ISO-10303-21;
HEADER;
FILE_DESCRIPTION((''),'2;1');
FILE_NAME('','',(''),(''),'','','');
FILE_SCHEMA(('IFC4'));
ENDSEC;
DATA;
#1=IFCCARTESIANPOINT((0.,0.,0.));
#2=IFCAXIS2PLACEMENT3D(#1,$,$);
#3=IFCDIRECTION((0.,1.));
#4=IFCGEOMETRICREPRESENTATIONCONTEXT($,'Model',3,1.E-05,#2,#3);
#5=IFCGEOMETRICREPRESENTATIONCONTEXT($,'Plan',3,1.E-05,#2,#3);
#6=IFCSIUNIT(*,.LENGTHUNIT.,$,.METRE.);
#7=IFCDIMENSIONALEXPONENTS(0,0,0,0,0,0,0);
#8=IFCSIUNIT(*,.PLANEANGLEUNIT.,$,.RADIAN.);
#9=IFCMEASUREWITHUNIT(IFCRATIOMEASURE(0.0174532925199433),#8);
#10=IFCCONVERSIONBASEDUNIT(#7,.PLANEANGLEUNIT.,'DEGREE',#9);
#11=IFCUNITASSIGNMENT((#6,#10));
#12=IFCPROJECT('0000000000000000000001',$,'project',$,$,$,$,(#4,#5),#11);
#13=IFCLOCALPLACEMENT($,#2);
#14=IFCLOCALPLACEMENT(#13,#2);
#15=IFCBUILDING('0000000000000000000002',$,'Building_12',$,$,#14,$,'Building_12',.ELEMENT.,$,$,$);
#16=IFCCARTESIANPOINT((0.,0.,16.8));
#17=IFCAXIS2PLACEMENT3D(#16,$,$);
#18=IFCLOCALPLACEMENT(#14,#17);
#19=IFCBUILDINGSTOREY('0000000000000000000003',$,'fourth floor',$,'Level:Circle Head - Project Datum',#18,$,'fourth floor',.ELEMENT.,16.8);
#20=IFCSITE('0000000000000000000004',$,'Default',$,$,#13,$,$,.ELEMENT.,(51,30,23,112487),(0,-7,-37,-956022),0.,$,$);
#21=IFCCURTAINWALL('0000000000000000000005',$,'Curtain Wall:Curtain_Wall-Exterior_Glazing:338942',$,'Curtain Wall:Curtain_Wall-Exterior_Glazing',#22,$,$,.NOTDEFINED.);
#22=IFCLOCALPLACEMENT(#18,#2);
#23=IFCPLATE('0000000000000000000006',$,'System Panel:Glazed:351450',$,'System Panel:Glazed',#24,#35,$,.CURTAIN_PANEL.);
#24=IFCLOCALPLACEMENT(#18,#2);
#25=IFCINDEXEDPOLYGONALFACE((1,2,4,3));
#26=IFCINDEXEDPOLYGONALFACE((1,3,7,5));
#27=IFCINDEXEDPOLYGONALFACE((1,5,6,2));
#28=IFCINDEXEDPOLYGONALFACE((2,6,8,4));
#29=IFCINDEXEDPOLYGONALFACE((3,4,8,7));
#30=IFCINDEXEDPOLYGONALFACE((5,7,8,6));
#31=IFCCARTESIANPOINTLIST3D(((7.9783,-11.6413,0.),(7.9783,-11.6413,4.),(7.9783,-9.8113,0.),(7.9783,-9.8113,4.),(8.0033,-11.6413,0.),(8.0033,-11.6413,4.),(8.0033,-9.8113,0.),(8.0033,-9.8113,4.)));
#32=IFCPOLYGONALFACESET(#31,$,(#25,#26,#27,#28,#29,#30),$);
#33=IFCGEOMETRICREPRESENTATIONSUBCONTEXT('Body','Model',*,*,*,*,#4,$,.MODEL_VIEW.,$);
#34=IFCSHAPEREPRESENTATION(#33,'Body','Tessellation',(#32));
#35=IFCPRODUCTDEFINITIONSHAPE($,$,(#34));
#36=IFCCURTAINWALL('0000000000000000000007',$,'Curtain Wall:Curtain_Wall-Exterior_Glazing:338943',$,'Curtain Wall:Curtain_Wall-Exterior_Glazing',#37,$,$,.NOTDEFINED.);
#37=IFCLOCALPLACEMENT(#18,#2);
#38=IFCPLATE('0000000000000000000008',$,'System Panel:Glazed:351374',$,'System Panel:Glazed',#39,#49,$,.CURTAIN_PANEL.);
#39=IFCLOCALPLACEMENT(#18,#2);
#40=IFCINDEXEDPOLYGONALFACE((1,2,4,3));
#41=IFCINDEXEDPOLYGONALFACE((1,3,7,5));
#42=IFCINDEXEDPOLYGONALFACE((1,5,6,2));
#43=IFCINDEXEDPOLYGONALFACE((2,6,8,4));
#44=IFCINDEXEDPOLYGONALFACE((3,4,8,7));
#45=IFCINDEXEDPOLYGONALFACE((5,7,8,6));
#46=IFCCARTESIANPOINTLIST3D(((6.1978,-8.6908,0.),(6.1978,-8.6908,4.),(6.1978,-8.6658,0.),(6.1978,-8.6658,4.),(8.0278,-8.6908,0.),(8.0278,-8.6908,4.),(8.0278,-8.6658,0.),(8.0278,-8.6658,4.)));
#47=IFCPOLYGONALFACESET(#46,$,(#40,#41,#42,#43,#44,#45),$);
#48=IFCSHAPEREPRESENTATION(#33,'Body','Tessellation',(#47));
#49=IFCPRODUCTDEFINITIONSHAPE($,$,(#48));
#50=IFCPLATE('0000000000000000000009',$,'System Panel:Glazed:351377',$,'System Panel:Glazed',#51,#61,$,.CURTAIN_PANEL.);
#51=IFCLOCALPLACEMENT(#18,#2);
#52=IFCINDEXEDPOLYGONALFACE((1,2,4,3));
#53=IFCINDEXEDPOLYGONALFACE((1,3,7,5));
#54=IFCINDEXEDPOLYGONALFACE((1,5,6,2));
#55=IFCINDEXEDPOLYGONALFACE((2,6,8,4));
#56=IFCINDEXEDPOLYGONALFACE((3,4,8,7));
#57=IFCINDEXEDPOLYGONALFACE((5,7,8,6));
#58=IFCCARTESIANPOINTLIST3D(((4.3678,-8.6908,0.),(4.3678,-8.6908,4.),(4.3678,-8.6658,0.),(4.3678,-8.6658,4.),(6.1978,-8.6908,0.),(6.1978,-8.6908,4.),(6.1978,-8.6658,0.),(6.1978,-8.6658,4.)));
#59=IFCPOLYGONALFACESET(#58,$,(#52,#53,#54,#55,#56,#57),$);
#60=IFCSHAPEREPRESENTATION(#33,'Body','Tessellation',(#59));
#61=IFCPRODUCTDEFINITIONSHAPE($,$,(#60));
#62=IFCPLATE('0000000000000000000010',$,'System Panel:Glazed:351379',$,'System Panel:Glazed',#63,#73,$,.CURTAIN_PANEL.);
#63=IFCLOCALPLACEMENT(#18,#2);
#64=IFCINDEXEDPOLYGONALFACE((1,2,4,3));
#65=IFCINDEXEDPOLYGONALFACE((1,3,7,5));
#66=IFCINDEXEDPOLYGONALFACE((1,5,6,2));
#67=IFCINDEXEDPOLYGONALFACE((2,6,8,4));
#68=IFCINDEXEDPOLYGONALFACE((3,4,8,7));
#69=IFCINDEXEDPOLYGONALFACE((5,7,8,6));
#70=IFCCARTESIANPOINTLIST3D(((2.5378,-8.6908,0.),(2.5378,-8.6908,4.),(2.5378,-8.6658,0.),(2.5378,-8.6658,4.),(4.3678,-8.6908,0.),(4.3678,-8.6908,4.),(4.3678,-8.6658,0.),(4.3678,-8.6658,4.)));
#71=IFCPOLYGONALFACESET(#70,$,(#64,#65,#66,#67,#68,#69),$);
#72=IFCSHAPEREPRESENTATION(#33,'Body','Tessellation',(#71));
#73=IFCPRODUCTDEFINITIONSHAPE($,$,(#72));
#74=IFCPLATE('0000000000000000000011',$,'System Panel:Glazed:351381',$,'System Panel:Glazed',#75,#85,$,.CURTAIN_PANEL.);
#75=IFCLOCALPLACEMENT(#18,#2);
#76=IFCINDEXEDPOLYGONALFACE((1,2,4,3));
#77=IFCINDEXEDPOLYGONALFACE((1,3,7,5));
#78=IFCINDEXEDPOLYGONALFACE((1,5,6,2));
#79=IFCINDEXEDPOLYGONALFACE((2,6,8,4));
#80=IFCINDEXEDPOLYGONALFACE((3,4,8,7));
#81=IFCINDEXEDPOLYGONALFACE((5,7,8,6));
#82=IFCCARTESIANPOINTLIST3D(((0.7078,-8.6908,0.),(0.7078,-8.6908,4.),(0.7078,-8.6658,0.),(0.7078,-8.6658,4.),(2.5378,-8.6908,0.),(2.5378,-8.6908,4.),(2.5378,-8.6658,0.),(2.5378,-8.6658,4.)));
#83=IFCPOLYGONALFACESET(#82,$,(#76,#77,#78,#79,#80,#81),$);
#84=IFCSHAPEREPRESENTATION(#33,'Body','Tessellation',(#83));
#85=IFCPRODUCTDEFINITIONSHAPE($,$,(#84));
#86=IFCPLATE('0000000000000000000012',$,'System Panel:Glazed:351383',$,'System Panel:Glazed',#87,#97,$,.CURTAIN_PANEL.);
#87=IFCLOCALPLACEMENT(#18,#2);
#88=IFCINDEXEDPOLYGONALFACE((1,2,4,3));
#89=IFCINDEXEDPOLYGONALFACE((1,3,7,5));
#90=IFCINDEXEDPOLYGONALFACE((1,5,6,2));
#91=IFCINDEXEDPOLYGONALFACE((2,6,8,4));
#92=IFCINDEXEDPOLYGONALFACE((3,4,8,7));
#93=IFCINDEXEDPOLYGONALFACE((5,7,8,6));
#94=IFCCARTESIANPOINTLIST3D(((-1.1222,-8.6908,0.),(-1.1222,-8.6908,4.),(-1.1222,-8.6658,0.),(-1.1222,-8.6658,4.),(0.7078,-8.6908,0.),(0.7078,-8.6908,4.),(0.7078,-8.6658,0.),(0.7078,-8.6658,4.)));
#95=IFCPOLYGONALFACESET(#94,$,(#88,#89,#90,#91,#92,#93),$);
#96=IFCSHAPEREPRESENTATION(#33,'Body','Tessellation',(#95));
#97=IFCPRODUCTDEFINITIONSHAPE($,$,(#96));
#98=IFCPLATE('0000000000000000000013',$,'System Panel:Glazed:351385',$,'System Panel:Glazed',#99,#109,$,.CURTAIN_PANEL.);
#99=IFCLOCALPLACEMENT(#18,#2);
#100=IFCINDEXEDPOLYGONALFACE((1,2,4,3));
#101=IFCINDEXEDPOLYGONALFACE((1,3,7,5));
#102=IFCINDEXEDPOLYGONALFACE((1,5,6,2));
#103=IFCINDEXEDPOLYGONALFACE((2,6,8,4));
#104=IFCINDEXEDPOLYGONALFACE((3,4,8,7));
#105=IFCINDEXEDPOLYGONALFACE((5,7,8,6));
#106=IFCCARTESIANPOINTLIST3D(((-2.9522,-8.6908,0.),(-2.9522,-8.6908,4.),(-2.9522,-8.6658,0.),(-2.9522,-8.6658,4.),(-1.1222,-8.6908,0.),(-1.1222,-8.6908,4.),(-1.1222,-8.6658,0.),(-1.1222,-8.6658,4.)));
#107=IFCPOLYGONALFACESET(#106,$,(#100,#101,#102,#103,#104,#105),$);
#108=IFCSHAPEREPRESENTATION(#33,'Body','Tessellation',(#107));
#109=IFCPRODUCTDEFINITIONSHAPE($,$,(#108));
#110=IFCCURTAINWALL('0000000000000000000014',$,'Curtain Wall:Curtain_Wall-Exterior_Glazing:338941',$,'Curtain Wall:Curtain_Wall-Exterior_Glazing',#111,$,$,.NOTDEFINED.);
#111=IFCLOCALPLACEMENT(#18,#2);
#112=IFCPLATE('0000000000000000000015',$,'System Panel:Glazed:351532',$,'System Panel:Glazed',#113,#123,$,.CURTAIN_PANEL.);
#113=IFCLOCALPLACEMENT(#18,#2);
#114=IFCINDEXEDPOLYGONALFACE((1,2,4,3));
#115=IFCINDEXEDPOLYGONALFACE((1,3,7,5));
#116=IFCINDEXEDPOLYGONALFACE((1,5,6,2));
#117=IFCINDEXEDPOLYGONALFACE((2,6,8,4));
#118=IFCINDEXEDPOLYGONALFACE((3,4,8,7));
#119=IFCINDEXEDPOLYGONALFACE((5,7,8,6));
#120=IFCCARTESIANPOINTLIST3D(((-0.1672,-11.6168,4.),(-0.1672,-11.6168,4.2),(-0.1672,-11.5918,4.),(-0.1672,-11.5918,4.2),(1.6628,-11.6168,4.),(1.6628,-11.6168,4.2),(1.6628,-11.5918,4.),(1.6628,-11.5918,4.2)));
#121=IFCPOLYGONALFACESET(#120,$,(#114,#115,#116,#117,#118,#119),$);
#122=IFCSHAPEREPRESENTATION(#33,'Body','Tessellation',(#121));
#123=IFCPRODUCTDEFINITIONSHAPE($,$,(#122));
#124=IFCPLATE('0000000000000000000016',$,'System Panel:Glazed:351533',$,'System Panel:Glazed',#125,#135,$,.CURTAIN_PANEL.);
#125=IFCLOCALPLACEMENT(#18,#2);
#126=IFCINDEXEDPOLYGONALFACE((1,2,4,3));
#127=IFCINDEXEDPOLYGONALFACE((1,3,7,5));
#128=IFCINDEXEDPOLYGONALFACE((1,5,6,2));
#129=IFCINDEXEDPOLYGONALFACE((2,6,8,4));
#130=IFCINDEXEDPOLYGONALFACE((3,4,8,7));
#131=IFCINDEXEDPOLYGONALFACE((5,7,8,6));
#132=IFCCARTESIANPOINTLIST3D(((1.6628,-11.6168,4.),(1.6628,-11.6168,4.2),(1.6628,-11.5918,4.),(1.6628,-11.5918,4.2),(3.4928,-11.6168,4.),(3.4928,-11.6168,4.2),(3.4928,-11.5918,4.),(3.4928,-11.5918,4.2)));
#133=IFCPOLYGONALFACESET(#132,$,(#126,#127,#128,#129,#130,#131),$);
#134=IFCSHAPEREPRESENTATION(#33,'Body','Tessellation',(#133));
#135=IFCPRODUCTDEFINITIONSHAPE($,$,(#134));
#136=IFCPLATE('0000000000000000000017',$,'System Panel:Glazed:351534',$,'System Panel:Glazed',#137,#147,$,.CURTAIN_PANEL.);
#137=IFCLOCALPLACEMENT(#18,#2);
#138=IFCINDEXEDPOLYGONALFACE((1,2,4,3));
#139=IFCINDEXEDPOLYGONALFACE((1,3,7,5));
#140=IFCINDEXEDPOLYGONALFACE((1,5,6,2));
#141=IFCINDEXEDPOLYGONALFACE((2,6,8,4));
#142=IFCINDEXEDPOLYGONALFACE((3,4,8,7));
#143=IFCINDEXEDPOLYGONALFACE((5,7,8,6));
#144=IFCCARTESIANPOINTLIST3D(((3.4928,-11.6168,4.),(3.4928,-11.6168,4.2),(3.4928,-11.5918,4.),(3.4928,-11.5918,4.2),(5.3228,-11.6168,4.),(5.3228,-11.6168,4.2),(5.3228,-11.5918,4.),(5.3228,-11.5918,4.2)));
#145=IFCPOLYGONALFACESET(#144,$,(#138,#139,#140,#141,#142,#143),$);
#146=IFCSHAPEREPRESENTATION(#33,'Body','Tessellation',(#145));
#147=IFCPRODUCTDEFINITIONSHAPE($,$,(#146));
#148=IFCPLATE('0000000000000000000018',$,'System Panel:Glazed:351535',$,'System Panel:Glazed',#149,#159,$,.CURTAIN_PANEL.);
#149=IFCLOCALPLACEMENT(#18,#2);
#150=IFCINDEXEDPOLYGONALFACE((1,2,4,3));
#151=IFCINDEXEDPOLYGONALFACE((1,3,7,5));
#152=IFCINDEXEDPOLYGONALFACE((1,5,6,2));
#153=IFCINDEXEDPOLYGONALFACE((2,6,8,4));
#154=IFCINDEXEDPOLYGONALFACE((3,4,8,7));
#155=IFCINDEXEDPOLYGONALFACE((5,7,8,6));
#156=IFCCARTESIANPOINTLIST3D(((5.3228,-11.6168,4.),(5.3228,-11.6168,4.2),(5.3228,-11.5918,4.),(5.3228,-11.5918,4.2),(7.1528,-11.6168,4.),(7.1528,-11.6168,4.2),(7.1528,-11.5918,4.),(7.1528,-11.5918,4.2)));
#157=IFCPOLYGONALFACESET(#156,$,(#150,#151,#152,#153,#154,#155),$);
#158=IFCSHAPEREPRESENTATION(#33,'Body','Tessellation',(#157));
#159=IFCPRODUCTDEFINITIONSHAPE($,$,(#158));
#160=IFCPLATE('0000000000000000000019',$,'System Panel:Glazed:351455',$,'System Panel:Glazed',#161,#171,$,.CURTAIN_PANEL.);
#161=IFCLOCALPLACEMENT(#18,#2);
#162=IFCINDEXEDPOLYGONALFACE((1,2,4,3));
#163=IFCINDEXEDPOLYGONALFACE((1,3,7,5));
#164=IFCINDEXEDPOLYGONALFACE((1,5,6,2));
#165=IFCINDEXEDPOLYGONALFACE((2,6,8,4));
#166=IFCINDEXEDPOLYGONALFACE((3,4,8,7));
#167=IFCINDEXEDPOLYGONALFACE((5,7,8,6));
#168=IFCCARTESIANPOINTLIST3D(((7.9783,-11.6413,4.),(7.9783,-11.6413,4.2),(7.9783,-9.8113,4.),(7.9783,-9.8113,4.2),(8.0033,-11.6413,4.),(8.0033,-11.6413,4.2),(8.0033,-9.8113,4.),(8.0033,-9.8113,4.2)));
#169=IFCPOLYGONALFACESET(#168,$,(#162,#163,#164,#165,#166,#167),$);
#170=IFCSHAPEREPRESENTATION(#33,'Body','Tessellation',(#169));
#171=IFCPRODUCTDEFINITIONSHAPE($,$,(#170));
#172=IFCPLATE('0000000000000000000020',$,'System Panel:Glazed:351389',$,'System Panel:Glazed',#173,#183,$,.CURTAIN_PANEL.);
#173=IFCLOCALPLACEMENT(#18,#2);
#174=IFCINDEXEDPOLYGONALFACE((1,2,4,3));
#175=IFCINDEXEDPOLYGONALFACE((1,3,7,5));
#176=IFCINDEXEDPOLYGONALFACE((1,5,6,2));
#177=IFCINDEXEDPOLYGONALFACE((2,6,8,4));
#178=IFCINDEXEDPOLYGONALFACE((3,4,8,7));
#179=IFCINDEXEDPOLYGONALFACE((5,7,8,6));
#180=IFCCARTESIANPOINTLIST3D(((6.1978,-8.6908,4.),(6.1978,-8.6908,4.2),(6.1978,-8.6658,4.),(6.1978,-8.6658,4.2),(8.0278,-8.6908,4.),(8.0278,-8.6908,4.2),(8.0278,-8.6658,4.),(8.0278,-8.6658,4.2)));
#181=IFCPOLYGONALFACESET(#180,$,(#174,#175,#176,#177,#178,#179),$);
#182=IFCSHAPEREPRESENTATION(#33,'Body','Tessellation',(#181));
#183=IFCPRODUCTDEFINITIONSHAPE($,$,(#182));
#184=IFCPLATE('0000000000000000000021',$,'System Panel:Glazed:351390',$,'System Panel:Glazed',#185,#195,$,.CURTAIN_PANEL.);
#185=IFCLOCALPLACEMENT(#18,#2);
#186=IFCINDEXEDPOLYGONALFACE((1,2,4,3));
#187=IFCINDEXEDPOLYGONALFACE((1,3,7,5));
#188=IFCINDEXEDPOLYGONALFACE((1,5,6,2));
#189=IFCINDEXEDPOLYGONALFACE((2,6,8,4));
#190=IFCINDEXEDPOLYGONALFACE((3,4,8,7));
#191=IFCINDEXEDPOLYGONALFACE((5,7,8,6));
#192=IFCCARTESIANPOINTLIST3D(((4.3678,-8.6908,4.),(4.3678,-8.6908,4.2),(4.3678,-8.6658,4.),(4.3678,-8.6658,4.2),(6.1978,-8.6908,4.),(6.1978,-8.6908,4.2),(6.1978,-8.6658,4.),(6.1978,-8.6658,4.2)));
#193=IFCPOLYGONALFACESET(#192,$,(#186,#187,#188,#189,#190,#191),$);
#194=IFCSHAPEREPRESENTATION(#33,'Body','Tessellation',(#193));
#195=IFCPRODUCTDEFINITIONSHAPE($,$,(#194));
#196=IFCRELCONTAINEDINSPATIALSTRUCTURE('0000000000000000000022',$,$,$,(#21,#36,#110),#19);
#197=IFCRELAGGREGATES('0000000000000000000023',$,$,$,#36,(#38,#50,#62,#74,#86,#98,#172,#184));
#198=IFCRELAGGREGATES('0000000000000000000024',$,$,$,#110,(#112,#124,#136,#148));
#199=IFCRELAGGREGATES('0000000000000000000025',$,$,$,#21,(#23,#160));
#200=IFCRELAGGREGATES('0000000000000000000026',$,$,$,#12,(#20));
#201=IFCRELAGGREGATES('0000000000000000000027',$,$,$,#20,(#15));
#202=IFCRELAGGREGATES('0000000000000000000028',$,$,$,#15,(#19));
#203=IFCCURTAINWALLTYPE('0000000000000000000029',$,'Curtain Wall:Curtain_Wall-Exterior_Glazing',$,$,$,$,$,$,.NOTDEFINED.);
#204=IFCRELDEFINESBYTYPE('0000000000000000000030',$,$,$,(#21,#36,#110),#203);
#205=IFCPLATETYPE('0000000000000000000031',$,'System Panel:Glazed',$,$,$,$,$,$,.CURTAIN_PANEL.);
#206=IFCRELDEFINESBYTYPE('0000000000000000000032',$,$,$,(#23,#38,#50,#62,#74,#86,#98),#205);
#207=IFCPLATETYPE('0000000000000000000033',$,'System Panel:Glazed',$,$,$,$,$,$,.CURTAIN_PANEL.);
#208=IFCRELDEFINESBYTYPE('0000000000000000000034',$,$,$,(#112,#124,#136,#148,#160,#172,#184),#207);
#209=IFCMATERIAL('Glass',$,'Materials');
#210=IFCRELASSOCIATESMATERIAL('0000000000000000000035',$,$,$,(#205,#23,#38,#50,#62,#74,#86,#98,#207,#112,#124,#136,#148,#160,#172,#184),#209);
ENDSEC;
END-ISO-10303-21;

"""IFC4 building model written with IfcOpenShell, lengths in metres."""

from ifc_helpers import new_model, entity, si_unit, converted_unit, direction, frame, origin, place, context, subcontext, project, spatial, indexed_curve, outline, extrude, source, transform, mapped, material, type_object, type_shapes, element, aggregate, save


model = new_model("IFC4")

# Units and contexts
model_context = context("Model", 3, precision=1e-05, world=origin(), true_north=direction((0.0, 1.0)))
plan_context = context("Plan", 3, precision=1e-05, world=origin(), true_north=direction((0.0, 1.0)))
body_context = subcontext(model_context, "Body", "Model", "MODEL_VIEW")
ifc_project = project(units=[si_unit("LENGTHUNIT", "METRE"), converted_unit("PLANEANGLEUNIT", "DEGREE", entity("IfcRatioMeasure", 0.0174532925199433), si_unit("PLANEANGLEUNIT", "RADIAN"), dimensions=[0, 0, 0, 0, 0, 0, 0])], contexts=[model_context, plan_context])

# Site, building, storey
site_placement = place(None, origin())
site = spatial("IfcSite", under=ifc_project, at=site_placement, Name="Default", CompositionType="ELEMENT", RefLatitude=(51, 30, 23, 112487), RefLongitude=(0, -7, -37, -956022), RefElevation=0.0)
building_placement = place(site_placement, origin())
building = spatial("IfcBuilding", under=site, at=building_placement, Name="Building_12", LongName="Building_12", CompositionType="ELEMENT")
storey_placement = place(building_placement, frame((0.0, 0.0, 16.8)))
storey = spatial("IfcBuildingStorey", under=building, at=storey_placement, Name="fourth floor", ObjectType="Level:Circle Head - Project Datum", LongName="fourth floor", CompositionType="ELEMENT", Elevation=16.8)

# Curtain wall, plate
curtain_wall_type = type_object("IfcCurtainWallType", Name="Curtain Wall:Curtain_Wall-Exterior_Glazing", PredefinedType="NOTDEFINED")
curtain_wall_1_placement = place(storey_placement, frame((0.0, 0.0, -16.8)))
curtain_wall_1 = element("IfcCurtainWall", 1, at=curtain_wall_1_placement, inside=storey, type_object=curtain_wall_type, Name="Curtain Wall:Curtain_Wall-Exterior_Glazing:338942", ObjectType="Curtain Wall:Curtain_Wall-Exterior_Glazing", PredefinedType="NOTDEFINED")
ifc_material = material(Name="Glass", Category="Materials")
plate_type_1 = type_object("IfcPlateType", Name="System Panel:Glazed", PredefinedType="CURTAIN_PANEL", material=ifc_material)
shared_shape_1 = source(origin(), body_context, "Body", "SweptSolid", [
    extrude(outline(indexed_curve([(-0.0125, -0.915), (0.0125, -0.915), (0.0125, 0.915), (-0.0125, 0.915), (-0.0125, -0.915)], self_intersect=False)), frame((0.0, 0.037, 0.0), z_axis=(0.0, 0.0, 1.0), x_axis=(0.0, 1.0, 0.0)), (0.0, 0.0, 1.0), 4.0),
])
type_shapes(plate_type_1, [shared_shape_1])
plate_1_placement = place(curtain_wall_1_placement, frame((8.0278, -10.7263, 16.8), z_axis=(0.0, 0.0, 1.0), x_axis=(0.0, 1.0, 0.0)))
plate_1 = element("IfcPlate", 2, at=plate_1_placement, type_object=plate_type_1, material=ifc_material, Name="System Panel:Glazed:351450", ObjectType="System Panel:Glazed", PredefinedType="CURTAIN_PANEL", context=body_context, shape_type="MappedRepresentation", body=[
    mapped(shared_shape_1, transform((0.0, 0.0, 0.0), scale=1.0)),
])

# Curtain walls, plates
curtain_wall_2_placement = place(storey_placement, frame((0.0, 0.0, -16.8)))
curtain_wall_2 = element("IfcCurtainWall", 3, at=curtain_wall_2_placement, inside=storey, type_object=curtain_wall_type, Name="Curtain Wall:Curtain_Wall-Exterior_Glazing:338943", ObjectType="Curtain Wall:Curtain_Wall-Exterior_Glazing", PredefinedType="NOTDEFINED")
plate_2_placement = place(curtain_wall_2_placement, frame((7.1128, -8.6413, 16.8), z_axis=(0.0, 0.0, 1.0), x_axis=(-1.0, 0.0, 0.0)))
plate_2 = element("IfcPlate", 4, at=plate_2_placement, type_object=plate_type_1, material=ifc_material, Name="System Panel:Glazed:351374", ObjectType="System Panel:Glazed", PredefinedType="CURTAIN_PANEL", context=body_context, shape_type="MappedRepresentation", body=[
    mapped(shared_shape_1, transform((0.0, 0.0, 0.0), scale=1.0)),
])
plate_3_placement = place(curtain_wall_2_placement, frame((5.2828, -8.6413, 16.8), z_axis=(0.0, 0.0, 1.0), x_axis=(-1.0, 0.0, 0.0)))
plate_3 = element("IfcPlate", 5, at=plate_3_placement, type_object=plate_type_1, material=ifc_material, Name="System Panel:Glazed:351377", ObjectType="System Panel:Glazed", PredefinedType="CURTAIN_PANEL", context=body_context, shape_type="MappedRepresentation", body=[
    mapped(shared_shape_1, transform((0.0, 0.0, 0.0), scale=1.0)),
])
plate_4_placement = place(curtain_wall_2_placement, frame((3.4528, -8.6413, 16.8), z_axis=(0.0, 0.0, 1.0), x_axis=(-1.0, 0.0, 0.0)))
plate_4 = element("IfcPlate", 6, at=plate_4_placement, type_object=plate_type_1, material=ifc_material, Name="System Panel:Glazed:351379", ObjectType="System Panel:Glazed", PredefinedType="CURTAIN_PANEL", context=body_context, shape_type="MappedRepresentation", body=[
    mapped(shared_shape_1, transform((0.0, 0.0, 0.0), scale=1.0)),
])
plate_5_placement = place(curtain_wall_2_placement, frame((1.6228, -8.6413, 16.8), z_axis=(0.0, 0.0, 1.0), x_axis=(-1.0, 0.0, 0.0)))
plate_5 = element("IfcPlate", 7, at=plate_5_placement, type_object=plate_type_1, material=ifc_material, Name="System Panel:Glazed:351381", ObjectType="System Panel:Glazed", PredefinedType="CURTAIN_PANEL", context=body_context, shape_type="MappedRepresentation", body=[
    mapped(shared_shape_1, transform((0.0, 0.0, 0.0), scale=1.0)),
])
plate_6_placement = place(curtain_wall_2_placement, frame((-0.2072, -8.6413, 16.8), z_axis=(0.0, 0.0, 1.0), x_axis=(-1.0, 0.0, 0.0)))
plate_6 = element("IfcPlate", 8, at=plate_6_placement, type_object=plate_type_1, material=ifc_material, Name="System Panel:Glazed:351383", ObjectType="System Panel:Glazed", PredefinedType="CURTAIN_PANEL", context=body_context, shape_type="MappedRepresentation", body=[
    mapped(shared_shape_1, transform((0.0, 0.0, 0.0), scale=1.0)),
])
plate_7_placement = place(curtain_wall_2_placement, frame((-2.0372, -8.6413, 16.8), z_axis=(0.0, 0.0, 1.0), x_axis=(-1.0, 0.0, 0.0)))
plate_7 = element("IfcPlate", 9, at=plate_7_placement, type_object=plate_type_1, material=ifc_material, Name="System Panel:Glazed:351385", ObjectType="System Panel:Glazed", PredefinedType="CURTAIN_PANEL", context=body_context, shape_type="MappedRepresentation", body=[
    mapped(shared_shape_1, transform((0.0, 0.0, 0.0), scale=1.0)),
])
curtain_wall_3_placement = place(storey_placement, frame((0.0, 0.0, -16.8)))
curtain_wall_3 = element("IfcCurtainWall", 10, at=curtain_wall_3_placement, inside=storey, type_object=curtain_wall_type, Name="Curtain Wall:Curtain_Wall-Exterior_Glazing:338941", ObjectType="Curtain Wall:Curtain_Wall-Exterior_Glazing", PredefinedType="NOTDEFINED")
plate_type_2 = type_object("IfcPlateType", Name="System Panel:Glazed", PredefinedType="CURTAIN_PANEL", material=ifc_material)
shared_shape_2 = source(origin(), body_context, "Body", "SweptSolid", [
    extrude(outline(indexed_curve([(-0.0125, -0.915), (0.0125, -0.915), (0.0125, 0.915), (-0.0125, 0.915), (-0.0125, -0.915)], self_intersect=False)), frame((0.0, 0.037, 0.0), z_axis=(0.0, 0.0, 1.0), x_axis=(0.0, 1.0, 0.0)), (0.0, 0.0, 1.0), 0.2),
])
type_shapes(plate_type_2, [shared_shape_2])
plate_8_placement = place(curtain_wall_3_placement, frame((0.7478, -11.6413, 20.8)))
plate_8 = element("IfcPlate", 11, at=plate_8_placement, type_object=plate_type_2, material=ifc_material, Name="System Panel:Glazed:351532", ObjectType="System Panel:Glazed", PredefinedType="CURTAIN_PANEL", context=body_context, shape_type="MappedRepresentation", body=[
    mapped(shared_shape_2, transform((0.0, 0.0, 0.0), scale=1.0)),
])
plate_9_placement = place(curtain_wall_3_placement, frame((2.5778, -11.6413, 20.8)))
plate_9 = element("IfcPlate", 12, at=plate_9_placement, type_object=plate_type_2, material=ifc_material, Name="System Panel:Glazed:351533", ObjectType="System Panel:Glazed", PredefinedType="CURTAIN_PANEL", context=body_context, shape_type="MappedRepresentation", body=[
    mapped(shared_shape_2, transform((0.0, 0.0, 0.0), scale=1.0)),
])
plate_10_placement = place(curtain_wall_3_placement, frame((4.4078, -11.6413, 20.8)))
plate_10 = element("IfcPlate", 13, at=plate_10_placement, type_object=plate_type_2, material=ifc_material, Name="System Panel:Glazed:351534", ObjectType="System Panel:Glazed", PredefinedType="CURTAIN_PANEL", context=body_context, shape_type="MappedRepresentation", body=[
    mapped(shared_shape_2, transform((0.0, 0.0, 0.0), scale=1.0)),
])
plate_11_placement = place(curtain_wall_3_placement, frame((6.2378, -11.6413, 20.8)))
plate_11 = element("IfcPlate", 14, at=plate_11_placement, type_object=plate_type_2, material=ifc_material, Name="System Panel:Glazed:351535", ObjectType="System Panel:Glazed", PredefinedType="CURTAIN_PANEL", context=body_context, shape_type="MappedRepresentation", body=[
    mapped(shared_shape_2, transform((0.0, 0.0, 0.0), scale=1.0)),
])

# Plates
plate_12_placement = place(curtain_wall_1_placement, frame((8.0278, -10.7263, 20.8), z_axis=(0.0, 0.0, 1.0), x_axis=(0.0, 1.0, 0.0)))
plate_12 = element("IfcPlate", 15, at=plate_12_placement, type_object=plate_type_2, material=ifc_material, Name="System Panel:Glazed:351455", ObjectType="System Panel:Glazed", PredefinedType="CURTAIN_PANEL", context=body_context, shape_type="MappedRepresentation", body=[
    mapped(shared_shape_2, transform((0.0, 0.0, 0.0), scale=1.0)),
])
plate_13_placement = place(curtain_wall_2_placement, frame((7.1128, -8.6413, 20.8), z_axis=(0.0, 0.0, 1.0), x_axis=(-1.0, 0.0, 0.0)))
plate_13 = element("IfcPlate", 16, at=plate_13_placement, type_object=plate_type_2, material=ifc_material, Name="System Panel:Glazed:351389", ObjectType="System Panel:Glazed", PredefinedType="CURTAIN_PANEL", context=body_context, shape_type="MappedRepresentation", body=[
    mapped(shared_shape_2, transform((0.0, 0.0, 0.0), scale=1.0)),
])
plate_14_placement = place(curtain_wall_2_placement, frame((5.2828, -8.6413, 20.8), z_axis=(0.0, 0.0, 1.0), x_axis=(-1.0, 0.0, 0.0)))
plate_14 = element("IfcPlate", 17, at=plate_14_placement, type_object=plate_type_2, material=ifc_material, Name="System Panel:Glazed:351390", ObjectType="System Panel:Glazed", PredefinedType="CURTAIN_PANEL", context=body_context, shape_type="MappedRepresentation", body=[
    mapped(shared_shape_2, transform((0.0, 0.0, 0.0), scale=1.0)),
])
aggregate(curtain_wall_2, [plate_2, plate_3, plate_4, plate_5, plate_6, plate_7, plate_13, plate_14])
aggregate(curtain_wall_3, [plate_8, plate_9, plate_10, plate_11])
aggregate(curtain_wall_1, [plate_1, plate_12])

save(model, "model.ifc")
